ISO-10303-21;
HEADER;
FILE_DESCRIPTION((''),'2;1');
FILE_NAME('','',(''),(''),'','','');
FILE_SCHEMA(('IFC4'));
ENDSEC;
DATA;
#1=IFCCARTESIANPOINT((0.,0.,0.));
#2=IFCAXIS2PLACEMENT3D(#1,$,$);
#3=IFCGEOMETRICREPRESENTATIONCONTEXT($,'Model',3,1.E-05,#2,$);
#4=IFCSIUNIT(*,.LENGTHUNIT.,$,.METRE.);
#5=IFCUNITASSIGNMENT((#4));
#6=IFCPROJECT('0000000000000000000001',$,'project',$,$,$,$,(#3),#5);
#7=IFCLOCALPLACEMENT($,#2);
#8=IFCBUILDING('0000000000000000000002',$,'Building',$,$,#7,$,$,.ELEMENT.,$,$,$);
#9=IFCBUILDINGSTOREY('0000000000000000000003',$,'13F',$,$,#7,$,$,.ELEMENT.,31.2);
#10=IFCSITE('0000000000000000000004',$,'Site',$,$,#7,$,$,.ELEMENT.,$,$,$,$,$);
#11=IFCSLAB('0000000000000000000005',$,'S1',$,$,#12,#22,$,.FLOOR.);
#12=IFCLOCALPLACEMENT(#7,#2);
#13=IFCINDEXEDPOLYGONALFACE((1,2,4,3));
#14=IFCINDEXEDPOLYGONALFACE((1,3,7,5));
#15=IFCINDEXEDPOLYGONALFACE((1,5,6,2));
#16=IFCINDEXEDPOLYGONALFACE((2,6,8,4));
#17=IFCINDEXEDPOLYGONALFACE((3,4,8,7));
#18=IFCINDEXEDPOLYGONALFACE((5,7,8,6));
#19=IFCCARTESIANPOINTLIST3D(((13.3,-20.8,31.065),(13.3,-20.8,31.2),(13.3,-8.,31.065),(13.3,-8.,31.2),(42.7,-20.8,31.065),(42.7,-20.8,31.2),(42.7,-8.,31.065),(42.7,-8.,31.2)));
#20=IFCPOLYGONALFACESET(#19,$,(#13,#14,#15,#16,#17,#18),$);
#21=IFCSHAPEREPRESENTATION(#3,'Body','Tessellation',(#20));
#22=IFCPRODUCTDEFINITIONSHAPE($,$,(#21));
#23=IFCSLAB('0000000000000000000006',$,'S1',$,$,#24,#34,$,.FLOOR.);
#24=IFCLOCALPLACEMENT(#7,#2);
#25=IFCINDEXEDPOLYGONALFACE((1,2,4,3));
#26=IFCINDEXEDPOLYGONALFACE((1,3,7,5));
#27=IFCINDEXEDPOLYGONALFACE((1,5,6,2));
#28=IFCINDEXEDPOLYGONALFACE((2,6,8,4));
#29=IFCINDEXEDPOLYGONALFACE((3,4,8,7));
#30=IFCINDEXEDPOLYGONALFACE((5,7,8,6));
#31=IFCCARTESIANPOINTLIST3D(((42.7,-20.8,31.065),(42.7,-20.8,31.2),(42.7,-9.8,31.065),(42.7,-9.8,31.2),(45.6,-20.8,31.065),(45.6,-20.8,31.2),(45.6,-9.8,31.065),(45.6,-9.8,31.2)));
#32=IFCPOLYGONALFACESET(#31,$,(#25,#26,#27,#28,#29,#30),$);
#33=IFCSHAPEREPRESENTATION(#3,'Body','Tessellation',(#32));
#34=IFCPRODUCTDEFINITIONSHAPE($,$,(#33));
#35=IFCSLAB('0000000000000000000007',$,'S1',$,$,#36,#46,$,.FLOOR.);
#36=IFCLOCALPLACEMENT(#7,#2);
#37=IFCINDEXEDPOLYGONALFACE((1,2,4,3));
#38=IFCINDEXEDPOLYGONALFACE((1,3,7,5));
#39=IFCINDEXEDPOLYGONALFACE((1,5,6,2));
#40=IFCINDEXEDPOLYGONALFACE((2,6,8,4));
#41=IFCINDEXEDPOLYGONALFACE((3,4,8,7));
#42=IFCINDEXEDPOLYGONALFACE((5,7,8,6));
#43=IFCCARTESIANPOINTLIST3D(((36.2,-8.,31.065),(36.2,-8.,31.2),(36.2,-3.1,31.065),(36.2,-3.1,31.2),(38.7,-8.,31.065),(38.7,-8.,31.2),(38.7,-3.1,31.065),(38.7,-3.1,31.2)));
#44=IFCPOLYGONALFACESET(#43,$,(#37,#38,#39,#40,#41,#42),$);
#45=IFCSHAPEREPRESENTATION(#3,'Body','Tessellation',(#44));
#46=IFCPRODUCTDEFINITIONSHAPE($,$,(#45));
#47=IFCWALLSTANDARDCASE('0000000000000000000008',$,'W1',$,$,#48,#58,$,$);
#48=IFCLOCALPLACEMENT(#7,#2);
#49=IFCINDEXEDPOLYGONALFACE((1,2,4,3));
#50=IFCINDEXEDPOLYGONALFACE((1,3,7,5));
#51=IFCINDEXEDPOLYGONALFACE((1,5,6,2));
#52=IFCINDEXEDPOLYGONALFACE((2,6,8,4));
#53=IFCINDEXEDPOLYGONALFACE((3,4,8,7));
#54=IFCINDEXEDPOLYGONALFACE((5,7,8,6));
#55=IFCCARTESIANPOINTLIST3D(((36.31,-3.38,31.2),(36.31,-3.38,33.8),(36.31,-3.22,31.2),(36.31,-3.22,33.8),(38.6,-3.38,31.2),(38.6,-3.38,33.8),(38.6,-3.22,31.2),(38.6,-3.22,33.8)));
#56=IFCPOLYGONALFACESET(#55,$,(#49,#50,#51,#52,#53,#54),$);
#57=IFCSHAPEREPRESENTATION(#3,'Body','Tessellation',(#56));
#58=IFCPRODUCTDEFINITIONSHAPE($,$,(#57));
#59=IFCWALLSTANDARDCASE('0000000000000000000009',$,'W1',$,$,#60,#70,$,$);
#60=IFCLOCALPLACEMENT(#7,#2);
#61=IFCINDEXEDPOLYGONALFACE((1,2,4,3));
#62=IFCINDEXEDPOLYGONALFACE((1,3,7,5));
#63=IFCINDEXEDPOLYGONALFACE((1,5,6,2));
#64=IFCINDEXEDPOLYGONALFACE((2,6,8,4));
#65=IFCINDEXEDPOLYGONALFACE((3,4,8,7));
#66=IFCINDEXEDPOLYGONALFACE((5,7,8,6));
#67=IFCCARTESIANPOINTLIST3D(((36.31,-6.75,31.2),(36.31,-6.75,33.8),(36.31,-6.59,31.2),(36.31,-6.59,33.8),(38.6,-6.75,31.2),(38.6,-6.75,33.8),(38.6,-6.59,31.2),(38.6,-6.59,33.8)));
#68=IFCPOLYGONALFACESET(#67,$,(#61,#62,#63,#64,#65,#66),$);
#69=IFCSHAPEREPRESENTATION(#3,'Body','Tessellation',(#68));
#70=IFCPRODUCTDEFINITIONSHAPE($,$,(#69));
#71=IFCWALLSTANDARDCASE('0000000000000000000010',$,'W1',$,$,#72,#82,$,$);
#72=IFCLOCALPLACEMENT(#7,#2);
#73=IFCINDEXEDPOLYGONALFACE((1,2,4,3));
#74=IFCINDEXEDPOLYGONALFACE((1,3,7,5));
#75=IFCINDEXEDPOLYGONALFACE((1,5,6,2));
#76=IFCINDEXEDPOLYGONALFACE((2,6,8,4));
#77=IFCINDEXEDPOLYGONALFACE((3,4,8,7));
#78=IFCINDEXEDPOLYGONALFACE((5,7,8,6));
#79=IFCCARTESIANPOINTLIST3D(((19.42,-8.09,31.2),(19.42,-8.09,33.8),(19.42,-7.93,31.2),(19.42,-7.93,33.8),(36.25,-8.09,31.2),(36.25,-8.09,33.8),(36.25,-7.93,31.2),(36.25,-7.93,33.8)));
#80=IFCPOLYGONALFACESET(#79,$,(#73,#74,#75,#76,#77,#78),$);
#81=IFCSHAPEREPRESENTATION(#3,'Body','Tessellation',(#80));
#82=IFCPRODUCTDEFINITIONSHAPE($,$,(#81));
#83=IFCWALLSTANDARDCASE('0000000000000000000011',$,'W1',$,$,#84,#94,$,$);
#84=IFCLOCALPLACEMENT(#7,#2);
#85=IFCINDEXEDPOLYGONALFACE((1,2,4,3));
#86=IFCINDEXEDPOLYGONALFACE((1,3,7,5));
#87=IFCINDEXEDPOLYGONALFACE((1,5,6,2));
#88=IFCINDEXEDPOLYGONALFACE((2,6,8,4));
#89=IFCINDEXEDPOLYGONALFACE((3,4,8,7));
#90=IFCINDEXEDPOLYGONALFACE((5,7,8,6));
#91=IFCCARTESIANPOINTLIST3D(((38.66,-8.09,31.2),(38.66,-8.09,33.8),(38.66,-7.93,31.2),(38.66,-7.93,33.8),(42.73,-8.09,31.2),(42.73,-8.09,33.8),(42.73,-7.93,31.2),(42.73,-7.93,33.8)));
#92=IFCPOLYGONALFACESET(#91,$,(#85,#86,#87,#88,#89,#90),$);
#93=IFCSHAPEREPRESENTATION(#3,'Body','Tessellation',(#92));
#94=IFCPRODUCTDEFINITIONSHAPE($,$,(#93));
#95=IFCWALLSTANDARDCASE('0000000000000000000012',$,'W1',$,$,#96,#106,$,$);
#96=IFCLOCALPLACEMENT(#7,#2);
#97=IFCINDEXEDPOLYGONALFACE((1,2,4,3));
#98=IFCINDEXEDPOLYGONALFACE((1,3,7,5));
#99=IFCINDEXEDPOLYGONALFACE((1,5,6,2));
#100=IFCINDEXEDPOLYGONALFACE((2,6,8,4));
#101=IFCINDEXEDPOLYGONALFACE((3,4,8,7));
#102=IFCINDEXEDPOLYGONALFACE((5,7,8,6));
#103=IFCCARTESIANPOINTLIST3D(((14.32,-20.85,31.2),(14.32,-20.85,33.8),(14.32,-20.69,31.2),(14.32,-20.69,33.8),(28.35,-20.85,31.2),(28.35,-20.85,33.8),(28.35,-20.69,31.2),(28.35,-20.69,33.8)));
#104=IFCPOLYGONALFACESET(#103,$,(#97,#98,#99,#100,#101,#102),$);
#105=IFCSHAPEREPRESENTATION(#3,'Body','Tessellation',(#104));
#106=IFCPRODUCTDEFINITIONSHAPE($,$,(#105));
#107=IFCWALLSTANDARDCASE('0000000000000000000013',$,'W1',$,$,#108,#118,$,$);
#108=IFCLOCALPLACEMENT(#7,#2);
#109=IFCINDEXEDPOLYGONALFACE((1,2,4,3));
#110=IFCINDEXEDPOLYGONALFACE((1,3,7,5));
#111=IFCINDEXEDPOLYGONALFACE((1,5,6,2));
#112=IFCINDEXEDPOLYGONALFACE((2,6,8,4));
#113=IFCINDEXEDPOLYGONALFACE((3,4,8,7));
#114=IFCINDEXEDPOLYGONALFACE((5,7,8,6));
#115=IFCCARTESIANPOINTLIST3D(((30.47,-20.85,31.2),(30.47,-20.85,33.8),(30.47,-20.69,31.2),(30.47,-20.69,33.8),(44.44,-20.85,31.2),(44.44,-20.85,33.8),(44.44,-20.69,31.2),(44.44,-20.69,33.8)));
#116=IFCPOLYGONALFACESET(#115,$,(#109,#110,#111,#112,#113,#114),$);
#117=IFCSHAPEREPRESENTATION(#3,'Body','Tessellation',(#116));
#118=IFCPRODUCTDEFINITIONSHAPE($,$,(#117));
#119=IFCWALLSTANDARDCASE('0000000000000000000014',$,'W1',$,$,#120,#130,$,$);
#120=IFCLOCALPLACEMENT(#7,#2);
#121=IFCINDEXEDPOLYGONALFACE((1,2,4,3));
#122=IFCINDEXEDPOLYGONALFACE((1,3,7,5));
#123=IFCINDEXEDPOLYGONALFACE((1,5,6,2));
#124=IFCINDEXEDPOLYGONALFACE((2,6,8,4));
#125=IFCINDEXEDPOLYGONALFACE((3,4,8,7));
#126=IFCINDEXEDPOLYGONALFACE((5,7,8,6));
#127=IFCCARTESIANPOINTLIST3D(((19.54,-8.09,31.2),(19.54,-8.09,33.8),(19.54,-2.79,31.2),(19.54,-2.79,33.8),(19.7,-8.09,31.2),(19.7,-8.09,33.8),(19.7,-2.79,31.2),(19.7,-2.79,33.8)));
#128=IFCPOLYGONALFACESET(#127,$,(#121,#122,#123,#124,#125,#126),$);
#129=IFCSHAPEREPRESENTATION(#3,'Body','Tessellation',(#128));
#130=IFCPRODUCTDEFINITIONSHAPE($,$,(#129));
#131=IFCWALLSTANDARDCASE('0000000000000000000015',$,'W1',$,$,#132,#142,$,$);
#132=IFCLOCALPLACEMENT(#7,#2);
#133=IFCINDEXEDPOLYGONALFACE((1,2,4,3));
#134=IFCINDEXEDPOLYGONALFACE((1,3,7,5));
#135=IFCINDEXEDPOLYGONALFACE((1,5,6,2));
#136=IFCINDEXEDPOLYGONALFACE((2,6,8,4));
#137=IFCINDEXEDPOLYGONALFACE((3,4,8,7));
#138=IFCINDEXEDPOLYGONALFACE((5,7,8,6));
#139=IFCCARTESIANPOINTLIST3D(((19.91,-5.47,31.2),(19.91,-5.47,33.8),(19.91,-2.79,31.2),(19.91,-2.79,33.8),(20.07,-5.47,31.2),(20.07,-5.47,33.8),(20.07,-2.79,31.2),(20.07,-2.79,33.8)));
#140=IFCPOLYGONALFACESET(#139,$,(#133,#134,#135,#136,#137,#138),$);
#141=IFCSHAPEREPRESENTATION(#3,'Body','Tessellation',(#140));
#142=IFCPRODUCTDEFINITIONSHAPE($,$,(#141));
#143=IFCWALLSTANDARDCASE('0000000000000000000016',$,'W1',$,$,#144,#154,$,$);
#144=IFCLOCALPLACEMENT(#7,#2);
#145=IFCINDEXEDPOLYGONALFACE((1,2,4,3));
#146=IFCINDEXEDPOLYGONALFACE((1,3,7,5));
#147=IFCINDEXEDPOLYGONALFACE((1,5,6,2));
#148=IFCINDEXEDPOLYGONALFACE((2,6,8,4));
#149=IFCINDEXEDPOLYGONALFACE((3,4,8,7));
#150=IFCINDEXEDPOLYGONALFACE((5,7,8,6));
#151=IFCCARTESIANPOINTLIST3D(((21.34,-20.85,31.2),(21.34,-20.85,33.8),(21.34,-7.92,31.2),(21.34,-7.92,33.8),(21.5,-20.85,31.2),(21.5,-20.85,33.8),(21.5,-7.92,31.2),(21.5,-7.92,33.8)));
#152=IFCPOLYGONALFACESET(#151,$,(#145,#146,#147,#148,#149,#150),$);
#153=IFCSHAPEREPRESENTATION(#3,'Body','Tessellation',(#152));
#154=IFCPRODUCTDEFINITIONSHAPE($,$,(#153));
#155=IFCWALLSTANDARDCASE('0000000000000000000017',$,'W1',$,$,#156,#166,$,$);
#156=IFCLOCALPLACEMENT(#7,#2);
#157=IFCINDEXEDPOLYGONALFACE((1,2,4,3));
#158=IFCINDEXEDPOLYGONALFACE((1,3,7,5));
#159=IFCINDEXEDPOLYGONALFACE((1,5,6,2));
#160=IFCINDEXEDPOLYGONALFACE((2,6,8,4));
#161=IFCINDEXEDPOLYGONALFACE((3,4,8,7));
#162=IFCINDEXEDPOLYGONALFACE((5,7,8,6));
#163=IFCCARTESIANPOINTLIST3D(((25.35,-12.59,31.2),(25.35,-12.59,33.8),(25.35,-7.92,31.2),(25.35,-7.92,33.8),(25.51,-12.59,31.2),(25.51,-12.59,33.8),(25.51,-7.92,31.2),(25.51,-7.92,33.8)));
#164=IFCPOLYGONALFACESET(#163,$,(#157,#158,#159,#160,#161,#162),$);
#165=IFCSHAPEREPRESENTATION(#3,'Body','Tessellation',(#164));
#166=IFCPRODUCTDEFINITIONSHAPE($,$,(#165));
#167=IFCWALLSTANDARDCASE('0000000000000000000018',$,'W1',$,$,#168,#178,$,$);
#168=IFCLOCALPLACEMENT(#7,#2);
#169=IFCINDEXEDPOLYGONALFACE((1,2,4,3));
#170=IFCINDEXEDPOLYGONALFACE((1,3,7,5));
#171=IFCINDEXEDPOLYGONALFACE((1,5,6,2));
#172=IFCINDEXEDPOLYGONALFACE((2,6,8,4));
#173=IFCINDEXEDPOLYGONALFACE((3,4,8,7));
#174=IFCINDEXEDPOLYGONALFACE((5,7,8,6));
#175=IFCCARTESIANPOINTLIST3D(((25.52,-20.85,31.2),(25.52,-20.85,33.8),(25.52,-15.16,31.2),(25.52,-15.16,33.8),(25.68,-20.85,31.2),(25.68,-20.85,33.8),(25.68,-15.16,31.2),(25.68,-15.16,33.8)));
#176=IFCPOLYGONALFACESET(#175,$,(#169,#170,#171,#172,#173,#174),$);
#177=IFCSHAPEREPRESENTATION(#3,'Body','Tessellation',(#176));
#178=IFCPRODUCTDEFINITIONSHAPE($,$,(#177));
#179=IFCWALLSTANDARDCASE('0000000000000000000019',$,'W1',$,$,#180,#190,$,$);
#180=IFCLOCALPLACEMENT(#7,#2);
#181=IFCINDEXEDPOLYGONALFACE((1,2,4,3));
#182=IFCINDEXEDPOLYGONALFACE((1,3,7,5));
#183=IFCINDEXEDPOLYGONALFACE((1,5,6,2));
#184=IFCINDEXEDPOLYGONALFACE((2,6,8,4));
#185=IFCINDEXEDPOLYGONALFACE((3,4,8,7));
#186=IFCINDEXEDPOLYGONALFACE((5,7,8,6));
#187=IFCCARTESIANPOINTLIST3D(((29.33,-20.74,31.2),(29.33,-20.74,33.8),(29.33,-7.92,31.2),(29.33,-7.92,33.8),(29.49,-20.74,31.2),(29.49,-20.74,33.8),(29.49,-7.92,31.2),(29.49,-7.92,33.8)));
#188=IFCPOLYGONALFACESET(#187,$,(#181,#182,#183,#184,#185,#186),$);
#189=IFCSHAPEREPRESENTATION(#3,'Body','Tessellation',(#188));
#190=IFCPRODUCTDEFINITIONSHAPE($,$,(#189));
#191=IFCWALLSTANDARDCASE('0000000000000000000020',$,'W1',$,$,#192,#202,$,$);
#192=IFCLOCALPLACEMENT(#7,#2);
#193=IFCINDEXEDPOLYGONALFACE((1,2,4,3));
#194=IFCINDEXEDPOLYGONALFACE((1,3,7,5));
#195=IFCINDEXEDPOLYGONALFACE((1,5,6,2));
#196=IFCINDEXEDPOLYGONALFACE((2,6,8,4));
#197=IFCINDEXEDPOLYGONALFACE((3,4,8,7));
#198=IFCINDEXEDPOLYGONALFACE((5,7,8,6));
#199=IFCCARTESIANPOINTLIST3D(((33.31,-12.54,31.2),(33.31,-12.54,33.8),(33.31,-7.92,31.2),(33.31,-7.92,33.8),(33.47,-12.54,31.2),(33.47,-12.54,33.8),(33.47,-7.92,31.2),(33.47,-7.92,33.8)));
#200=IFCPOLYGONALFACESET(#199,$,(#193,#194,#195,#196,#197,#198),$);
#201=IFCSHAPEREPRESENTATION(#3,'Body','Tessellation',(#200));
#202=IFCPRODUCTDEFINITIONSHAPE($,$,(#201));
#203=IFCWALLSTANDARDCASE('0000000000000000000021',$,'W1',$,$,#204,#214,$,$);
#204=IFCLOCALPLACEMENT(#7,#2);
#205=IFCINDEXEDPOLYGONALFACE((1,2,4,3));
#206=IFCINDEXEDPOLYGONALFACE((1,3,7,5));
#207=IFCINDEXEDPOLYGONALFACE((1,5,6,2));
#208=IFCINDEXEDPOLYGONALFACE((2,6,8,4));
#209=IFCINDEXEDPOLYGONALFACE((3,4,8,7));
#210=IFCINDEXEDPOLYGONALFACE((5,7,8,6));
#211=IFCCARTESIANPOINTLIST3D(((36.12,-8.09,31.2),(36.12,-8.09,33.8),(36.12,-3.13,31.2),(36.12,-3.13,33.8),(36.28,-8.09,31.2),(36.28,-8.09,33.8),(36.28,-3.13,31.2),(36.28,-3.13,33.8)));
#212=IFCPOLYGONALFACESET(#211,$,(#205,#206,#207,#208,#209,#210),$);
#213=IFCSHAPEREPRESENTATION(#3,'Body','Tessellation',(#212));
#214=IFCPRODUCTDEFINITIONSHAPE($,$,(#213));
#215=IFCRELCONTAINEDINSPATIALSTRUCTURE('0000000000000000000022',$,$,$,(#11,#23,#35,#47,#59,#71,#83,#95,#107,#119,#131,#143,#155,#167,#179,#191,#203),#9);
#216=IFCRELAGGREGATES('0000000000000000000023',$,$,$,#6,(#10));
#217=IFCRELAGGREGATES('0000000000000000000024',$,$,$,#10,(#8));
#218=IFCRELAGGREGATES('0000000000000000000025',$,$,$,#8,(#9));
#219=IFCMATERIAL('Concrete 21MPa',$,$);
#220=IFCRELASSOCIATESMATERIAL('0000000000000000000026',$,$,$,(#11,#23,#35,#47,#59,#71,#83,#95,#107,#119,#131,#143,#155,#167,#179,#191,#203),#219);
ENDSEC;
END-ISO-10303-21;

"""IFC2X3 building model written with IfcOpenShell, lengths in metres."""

from ifc_helpers import new_model, si_unit, frame, origin, origin_2d, place, context, project, spatial, rectangle, extrude, material, element, save


model = new_model("IFC2X3")

# Units and contexts
model_context = context("Model", 3, precision=1e-05, world=origin())
ifc_project = project(units=[si_unit("LENGTHUNIT", "METRE")], contexts=[model_context])

# Site, building, storey
placement = place(None, origin())
site = spatial("IfcSite", under=ifc_project, at=placement, Name="Site", CompositionType="ELEMENT")
building = spatial("IfcBuilding", under=site, at=placement, Name="Building", CompositionType="ELEMENT")
storey = spatial("IfcBuildingStorey", under=building, at=placement, Name="13F", CompositionType="ELEMENT", Elevation=31.2)

# Slabs
ifc_material_1 = material(Name="Concrete 21MPa")
slab_1_placement = place(None, frame((28.0, -14.4, 31.065)))
element("IfcSlab", 1, at=slab_1_placement, inside=storey, material=ifc_material_1, Name="S1", PredefinedType="FLOOR", context=model_context, shape_type="SweptSolid", body=[
    extrude(rectangle(XDim=29.4, YDim=12.8, at=origin_2d()), origin(), (0.0, 0.0, 1.0), 0.135),
])
slab_2_placement = place(None, frame((44.15, -15.3, 31.065)))
element("IfcSlab", 2, at=slab_2_placement, inside=storey, material=ifc_material_1, Name="S1", PredefinedType="FLOOR", context=model_context, shape_type="SweptSolid", body=[
    extrude(rectangle(XDim=2.9, YDim=11.0, at=origin_2d()), origin(), (0.0, 0.0, 1.0), 0.135),
])
slab_3_placement = place(None, frame((37.45, -5.55, 31.065)))
element("IfcSlab", 3, at=slab_3_placement, inside=storey, material=ifc_material_1, Name="S1", PredefinedType="FLOOR", context=model_context, shape_type="SweptSolid", body=[
    extrude(rectangle(XDim=2.5, YDim=4.9, at=origin_2d()), origin(), (0.0, 0.0, 1.0), 0.135),
])

# Walls
for number, where, name in (
    (4, (37.455, -3.3, 31.2), "W1"),
    (5, (37.455, -6.67, 31.2), "W1"),
):
    element("IfcWallStandardCase", number, at=place(None, frame(where)), inside=storey, material=ifc_material_1, Name=name, context=model_context, shape_type="SweptSolid", body=[
        extrude(rectangle(XDim=2.29, YDim=0.16, at=origin_2d()), origin(), (0.0, 0.0, 1.0), 2.6),
    ])
wall_1_placement = place(None, frame((27.835, -8.01, 31.2)))
element("IfcWallStandardCase", 6, at=wall_1_placement, inside=storey, material=ifc_material_1, Name="W1", context=model_context, shape_type="SweptSolid", body=[
    extrude(rectangle(XDim=16.83, YDim=0.16, at=origin_2d()), origin(), (0.0, 0.0, 1.0), 2.6),
])
wall_2_placement = place(None, frame((40.695, -8.01, 31.2)))
element("IfcWallStandardCase", 7, at=wall_2_placement, inside=storey, material=ifc_material_1, Name="W1", context=model_context, shape_type="SweptSolid", body=[
    extrude(rectangle(XDim=4.07, YDim=0.16, at=origin_2d()), origin(), (0.0, 0.0, 1.0), 2.6),
])
wall_3_placement = place(None, frame((21.335, -20.77, 31.2)))
element("IfcWallStandardCase", 8, at=wall_3_placement, inside=storey, material=ifc_material_1, Name="W1", context=model_context, shape_type="SweptSolid", body=[
    extrude(rectangle(XDim=14.03, YDim=0.16, at=origin_2d()), origin(), (0.0, 0.0, 1.0), 2.6),
])
wall_4_placement = place(None, frame((37.455, -20.77, 31.2)))
element("IfcWallStandardCase", 9, at=wall_4_placement, inside=storey, material=ifc_material_1, Name="W1", context=model_context, shape_type="SweptSolid", body=[
    extrude(rectangle(XDim=13.97, YDim=0.16, at=origin_2d()), origin(), (0.0, 0.0, 1.0), 2.6),
])
wall_5_placement = place(None, frame((19.62, -5.44, 31.2)))
element("IfcWallStandardCase", 10, at=wall_5_placement, inside=storey, material=ifc_material_1, Name="W1", context=model_context, shape_type="SweptSolid", body=[
    extrude(rectangle(XDim=0.16, YDim=5.3, at=origin_2d()), origin(), (0.0, 0.0, 1.0), 2.6),
])
wall_6_placement = place(None, frame((19.99, -4.13, 31.2)))
element("IfcWallStandardCase", 11, at=wall_6_placement, inside=storey, material=ifc_material_1, Name="W1", context=model_context, shape_type="SweptSolid", body=[
    extrude(rectangle(XDim=0.16, YDim=2.68, at=origin_2d()), origin(), (0.0, 0.0, 1.0), 2.6),
])
wall_7_placement = place(None, frame((21.42, -14.385, 31.2)))
element("IfcWallStandardCase", 12, at=wall_7_placement, inside=storey, material=ifc_material_1, Name="W1", context=model_context, shape_type="SweptSolid", body=[
    extrude(rectangle(XDim=0.16, YDim=12.93, at=origin_2d()), origin(), (0.0, 0.0, 1.0), 2.6),
])
wall_8_placement = place(None, frame((25.43, -10.255, 31.2)))
element("IfcWallStandardCase", 13, at=wall_8_placement, inside=storey, material=ifc_material_1, Name="W1", context=model_context, shape_type="SweptSolid", body=[
    extrude(rectangle(XDim=0.16, YDim=4.67, at=origin_2d()), origin(), (0.0, 0.0, 1.0), 2.6),
])
wall_9_placement = place(None, frame((25.6, -18.005, 31.2)))
element("IfcWallStandardCase", 14, at=wall_9_placement, inside=storey, material=ifc_material_1, Name="W1", context=model_context, shape_type="SweptSolid", body=[
    extrude(rectangle(XDim=0.16, YDim=5.69, at=origin_2d()), origin(), (0.0, 0.0, 1.0), 2.6),
])
wall_10_placement = place(None, frame((29.41, -14.33, 31.2)))
element("IfcWallStandardCase", 15, at=wall_10_placement, inside=storey, material=ifc_material_1, Name="W1", context=model_context, shape_type="SweptSolid", body=[
    extrude(rectangle(XDim=0.16, YDim=12.82, at=origin_2d()), origin(), (0.0, 0.0, 1.0), 2.6),
])
wall_11_placement = place(None, frame((33.39, -10.23, 31.2)))
element("IfcWallStandardCase", 16, at=wall_11_placement, inside=storey, material=ifc_material_1, Name="W1", context=model_context, shape_type="SweptSolid", body=[
    extrude(rectangle(XDim=0.16, YDim=4.62, at=origin_2d()), origin(), (0.0, 0.0, 1.0), 2.6),
])
wall_12_placement = place(None, frame((36.2, -5.61, 31.2)))
element("IfcWallStandardCase", 17, at=wall_12_placement, inside=storey, material=ifc_material_1, Name="W1", context=model_context, shape_type="SweptSolid", body=[
    extrude(rectangle(XDim=0.16, YDim=4.96, at=origin_2d()), origin(), (0.0, 0.0, 1.0), 2.6),
])

save(model, "model.ifc")
